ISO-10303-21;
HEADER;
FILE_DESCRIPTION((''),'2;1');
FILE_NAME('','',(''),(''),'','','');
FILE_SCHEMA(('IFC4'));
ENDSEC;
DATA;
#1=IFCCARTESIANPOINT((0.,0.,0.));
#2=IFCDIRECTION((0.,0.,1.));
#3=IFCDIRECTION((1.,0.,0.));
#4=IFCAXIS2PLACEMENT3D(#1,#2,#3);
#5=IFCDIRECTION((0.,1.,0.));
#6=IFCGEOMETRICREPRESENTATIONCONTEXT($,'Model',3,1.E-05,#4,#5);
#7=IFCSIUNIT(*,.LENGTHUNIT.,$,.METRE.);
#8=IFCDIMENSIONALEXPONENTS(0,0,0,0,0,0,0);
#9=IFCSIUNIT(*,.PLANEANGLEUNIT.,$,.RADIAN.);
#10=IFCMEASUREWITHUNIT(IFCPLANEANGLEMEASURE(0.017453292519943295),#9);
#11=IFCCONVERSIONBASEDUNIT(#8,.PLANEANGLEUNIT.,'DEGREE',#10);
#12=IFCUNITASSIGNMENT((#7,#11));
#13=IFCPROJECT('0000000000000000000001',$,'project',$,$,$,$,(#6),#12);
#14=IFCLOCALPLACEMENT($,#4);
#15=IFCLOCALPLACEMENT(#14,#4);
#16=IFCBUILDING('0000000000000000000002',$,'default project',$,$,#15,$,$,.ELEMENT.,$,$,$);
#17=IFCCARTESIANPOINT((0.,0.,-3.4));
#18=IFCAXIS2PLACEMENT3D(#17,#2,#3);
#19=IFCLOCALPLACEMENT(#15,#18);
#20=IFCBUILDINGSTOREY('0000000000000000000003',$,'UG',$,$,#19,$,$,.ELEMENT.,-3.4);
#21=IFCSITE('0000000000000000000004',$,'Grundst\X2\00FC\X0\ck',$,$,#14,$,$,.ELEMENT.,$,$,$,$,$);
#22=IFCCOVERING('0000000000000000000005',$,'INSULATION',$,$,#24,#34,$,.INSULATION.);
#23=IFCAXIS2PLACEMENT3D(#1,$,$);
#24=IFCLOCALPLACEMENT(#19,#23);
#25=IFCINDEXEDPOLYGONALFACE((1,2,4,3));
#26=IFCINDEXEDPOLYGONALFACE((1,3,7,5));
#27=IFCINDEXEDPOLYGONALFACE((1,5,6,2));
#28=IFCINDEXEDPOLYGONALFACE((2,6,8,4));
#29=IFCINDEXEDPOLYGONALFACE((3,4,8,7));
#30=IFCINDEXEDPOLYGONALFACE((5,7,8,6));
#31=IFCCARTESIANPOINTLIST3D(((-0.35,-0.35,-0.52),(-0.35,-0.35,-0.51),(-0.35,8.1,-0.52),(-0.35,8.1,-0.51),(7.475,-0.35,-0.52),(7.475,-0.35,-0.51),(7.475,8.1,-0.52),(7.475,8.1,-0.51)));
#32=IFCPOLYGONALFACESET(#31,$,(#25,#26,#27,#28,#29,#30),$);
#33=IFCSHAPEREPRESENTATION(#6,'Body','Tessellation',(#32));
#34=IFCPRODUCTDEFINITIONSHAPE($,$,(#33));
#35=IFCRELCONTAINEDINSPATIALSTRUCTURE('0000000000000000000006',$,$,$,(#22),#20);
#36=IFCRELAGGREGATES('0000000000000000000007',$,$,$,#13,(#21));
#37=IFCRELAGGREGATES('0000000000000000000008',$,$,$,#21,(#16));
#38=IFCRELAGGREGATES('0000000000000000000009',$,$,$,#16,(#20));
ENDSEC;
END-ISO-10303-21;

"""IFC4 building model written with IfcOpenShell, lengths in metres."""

from ifc_helpers import new_model, entity, si_unit, converted_unit, direction, frame, origin_with_axes, place, context, project, spatial, polyline, outline, extrude, element, save


model = new_model("IFC4")

# Units and contexts
model_context = context("Model", 3, precision=1e-05, world=origin_with_axes(), true_north=direction((0.0, 1.0, 0.0)))
ifc_project = project(units=[si_unit("LENGTHUNIT", "METRE"), converted_unit("PLANEANGLEUNIT", "DEGREE", entity("IfcPlaneAngleMeasure", 0.017453292519943295), si_unit("PLANEANGLEUNIT", "RADIAN"), dimensions=[0, 0, 0, 0, 0, 0, 0])], contexts=[model_context])

# Site, building, storey
site_placement = place(None, origin_with_axes())
site = spatial("IfcSite", under=ifc_project, at=site_placement, Name="Grundstück", CompositionType="ELEMENT")
building_placement = place(site_placement, origin_with_axes())
building = spatial("IfcBuilding", under=site, at=building_placement, Name="default project", CompositionType="ELEMENT")
placement_1 = place(building_placement, frame((0.0, 0.0, -3.4), z_axis=(0.0, 0.0, 1.0), x_axis=(1.0, 0.0, 0.0)))
storey = spatial("IfcBuildingStorey", under=building, at=placement_1, Name="UG", CompositionType="ELEMENT", Elevation=-3.4)

# Shared definitions
slab_placement = place(placement_1, frame((0.0, 0.0, -0.5), z_axis=(0.0, 0.0, 1.0), x_axis=(1.0, 0.0, 0.0)))

# Covering
covering_1_placement = place(slab_placement, frame((0.0, 0.0, -0.01), z_axis=(0.0, 0.0, 1.0), x_axis=(1.0, 0.0, 0.0)))
element("IfcCovering", 1, at=covering_1_placement, inside=storey, Name="INSULATION", PredefinedType="INSULATION", context=model_context, shape_type="SweptSolid", body=[
    extrude(outline(polyline([(7.475, 8.1), (-0.35, 8.1), (-0.35, -0.35), (7.475, -0.35), (7.475, 8.1)])), frame((0.0, 0.0, -0.01), z_axis=(0.0, 0.0, 1.0), x_axis=(1.0, 0.0, 0.0)), (0.0, 0.0, 1.0), 0.01),
])

save(model, "model.ifc")
